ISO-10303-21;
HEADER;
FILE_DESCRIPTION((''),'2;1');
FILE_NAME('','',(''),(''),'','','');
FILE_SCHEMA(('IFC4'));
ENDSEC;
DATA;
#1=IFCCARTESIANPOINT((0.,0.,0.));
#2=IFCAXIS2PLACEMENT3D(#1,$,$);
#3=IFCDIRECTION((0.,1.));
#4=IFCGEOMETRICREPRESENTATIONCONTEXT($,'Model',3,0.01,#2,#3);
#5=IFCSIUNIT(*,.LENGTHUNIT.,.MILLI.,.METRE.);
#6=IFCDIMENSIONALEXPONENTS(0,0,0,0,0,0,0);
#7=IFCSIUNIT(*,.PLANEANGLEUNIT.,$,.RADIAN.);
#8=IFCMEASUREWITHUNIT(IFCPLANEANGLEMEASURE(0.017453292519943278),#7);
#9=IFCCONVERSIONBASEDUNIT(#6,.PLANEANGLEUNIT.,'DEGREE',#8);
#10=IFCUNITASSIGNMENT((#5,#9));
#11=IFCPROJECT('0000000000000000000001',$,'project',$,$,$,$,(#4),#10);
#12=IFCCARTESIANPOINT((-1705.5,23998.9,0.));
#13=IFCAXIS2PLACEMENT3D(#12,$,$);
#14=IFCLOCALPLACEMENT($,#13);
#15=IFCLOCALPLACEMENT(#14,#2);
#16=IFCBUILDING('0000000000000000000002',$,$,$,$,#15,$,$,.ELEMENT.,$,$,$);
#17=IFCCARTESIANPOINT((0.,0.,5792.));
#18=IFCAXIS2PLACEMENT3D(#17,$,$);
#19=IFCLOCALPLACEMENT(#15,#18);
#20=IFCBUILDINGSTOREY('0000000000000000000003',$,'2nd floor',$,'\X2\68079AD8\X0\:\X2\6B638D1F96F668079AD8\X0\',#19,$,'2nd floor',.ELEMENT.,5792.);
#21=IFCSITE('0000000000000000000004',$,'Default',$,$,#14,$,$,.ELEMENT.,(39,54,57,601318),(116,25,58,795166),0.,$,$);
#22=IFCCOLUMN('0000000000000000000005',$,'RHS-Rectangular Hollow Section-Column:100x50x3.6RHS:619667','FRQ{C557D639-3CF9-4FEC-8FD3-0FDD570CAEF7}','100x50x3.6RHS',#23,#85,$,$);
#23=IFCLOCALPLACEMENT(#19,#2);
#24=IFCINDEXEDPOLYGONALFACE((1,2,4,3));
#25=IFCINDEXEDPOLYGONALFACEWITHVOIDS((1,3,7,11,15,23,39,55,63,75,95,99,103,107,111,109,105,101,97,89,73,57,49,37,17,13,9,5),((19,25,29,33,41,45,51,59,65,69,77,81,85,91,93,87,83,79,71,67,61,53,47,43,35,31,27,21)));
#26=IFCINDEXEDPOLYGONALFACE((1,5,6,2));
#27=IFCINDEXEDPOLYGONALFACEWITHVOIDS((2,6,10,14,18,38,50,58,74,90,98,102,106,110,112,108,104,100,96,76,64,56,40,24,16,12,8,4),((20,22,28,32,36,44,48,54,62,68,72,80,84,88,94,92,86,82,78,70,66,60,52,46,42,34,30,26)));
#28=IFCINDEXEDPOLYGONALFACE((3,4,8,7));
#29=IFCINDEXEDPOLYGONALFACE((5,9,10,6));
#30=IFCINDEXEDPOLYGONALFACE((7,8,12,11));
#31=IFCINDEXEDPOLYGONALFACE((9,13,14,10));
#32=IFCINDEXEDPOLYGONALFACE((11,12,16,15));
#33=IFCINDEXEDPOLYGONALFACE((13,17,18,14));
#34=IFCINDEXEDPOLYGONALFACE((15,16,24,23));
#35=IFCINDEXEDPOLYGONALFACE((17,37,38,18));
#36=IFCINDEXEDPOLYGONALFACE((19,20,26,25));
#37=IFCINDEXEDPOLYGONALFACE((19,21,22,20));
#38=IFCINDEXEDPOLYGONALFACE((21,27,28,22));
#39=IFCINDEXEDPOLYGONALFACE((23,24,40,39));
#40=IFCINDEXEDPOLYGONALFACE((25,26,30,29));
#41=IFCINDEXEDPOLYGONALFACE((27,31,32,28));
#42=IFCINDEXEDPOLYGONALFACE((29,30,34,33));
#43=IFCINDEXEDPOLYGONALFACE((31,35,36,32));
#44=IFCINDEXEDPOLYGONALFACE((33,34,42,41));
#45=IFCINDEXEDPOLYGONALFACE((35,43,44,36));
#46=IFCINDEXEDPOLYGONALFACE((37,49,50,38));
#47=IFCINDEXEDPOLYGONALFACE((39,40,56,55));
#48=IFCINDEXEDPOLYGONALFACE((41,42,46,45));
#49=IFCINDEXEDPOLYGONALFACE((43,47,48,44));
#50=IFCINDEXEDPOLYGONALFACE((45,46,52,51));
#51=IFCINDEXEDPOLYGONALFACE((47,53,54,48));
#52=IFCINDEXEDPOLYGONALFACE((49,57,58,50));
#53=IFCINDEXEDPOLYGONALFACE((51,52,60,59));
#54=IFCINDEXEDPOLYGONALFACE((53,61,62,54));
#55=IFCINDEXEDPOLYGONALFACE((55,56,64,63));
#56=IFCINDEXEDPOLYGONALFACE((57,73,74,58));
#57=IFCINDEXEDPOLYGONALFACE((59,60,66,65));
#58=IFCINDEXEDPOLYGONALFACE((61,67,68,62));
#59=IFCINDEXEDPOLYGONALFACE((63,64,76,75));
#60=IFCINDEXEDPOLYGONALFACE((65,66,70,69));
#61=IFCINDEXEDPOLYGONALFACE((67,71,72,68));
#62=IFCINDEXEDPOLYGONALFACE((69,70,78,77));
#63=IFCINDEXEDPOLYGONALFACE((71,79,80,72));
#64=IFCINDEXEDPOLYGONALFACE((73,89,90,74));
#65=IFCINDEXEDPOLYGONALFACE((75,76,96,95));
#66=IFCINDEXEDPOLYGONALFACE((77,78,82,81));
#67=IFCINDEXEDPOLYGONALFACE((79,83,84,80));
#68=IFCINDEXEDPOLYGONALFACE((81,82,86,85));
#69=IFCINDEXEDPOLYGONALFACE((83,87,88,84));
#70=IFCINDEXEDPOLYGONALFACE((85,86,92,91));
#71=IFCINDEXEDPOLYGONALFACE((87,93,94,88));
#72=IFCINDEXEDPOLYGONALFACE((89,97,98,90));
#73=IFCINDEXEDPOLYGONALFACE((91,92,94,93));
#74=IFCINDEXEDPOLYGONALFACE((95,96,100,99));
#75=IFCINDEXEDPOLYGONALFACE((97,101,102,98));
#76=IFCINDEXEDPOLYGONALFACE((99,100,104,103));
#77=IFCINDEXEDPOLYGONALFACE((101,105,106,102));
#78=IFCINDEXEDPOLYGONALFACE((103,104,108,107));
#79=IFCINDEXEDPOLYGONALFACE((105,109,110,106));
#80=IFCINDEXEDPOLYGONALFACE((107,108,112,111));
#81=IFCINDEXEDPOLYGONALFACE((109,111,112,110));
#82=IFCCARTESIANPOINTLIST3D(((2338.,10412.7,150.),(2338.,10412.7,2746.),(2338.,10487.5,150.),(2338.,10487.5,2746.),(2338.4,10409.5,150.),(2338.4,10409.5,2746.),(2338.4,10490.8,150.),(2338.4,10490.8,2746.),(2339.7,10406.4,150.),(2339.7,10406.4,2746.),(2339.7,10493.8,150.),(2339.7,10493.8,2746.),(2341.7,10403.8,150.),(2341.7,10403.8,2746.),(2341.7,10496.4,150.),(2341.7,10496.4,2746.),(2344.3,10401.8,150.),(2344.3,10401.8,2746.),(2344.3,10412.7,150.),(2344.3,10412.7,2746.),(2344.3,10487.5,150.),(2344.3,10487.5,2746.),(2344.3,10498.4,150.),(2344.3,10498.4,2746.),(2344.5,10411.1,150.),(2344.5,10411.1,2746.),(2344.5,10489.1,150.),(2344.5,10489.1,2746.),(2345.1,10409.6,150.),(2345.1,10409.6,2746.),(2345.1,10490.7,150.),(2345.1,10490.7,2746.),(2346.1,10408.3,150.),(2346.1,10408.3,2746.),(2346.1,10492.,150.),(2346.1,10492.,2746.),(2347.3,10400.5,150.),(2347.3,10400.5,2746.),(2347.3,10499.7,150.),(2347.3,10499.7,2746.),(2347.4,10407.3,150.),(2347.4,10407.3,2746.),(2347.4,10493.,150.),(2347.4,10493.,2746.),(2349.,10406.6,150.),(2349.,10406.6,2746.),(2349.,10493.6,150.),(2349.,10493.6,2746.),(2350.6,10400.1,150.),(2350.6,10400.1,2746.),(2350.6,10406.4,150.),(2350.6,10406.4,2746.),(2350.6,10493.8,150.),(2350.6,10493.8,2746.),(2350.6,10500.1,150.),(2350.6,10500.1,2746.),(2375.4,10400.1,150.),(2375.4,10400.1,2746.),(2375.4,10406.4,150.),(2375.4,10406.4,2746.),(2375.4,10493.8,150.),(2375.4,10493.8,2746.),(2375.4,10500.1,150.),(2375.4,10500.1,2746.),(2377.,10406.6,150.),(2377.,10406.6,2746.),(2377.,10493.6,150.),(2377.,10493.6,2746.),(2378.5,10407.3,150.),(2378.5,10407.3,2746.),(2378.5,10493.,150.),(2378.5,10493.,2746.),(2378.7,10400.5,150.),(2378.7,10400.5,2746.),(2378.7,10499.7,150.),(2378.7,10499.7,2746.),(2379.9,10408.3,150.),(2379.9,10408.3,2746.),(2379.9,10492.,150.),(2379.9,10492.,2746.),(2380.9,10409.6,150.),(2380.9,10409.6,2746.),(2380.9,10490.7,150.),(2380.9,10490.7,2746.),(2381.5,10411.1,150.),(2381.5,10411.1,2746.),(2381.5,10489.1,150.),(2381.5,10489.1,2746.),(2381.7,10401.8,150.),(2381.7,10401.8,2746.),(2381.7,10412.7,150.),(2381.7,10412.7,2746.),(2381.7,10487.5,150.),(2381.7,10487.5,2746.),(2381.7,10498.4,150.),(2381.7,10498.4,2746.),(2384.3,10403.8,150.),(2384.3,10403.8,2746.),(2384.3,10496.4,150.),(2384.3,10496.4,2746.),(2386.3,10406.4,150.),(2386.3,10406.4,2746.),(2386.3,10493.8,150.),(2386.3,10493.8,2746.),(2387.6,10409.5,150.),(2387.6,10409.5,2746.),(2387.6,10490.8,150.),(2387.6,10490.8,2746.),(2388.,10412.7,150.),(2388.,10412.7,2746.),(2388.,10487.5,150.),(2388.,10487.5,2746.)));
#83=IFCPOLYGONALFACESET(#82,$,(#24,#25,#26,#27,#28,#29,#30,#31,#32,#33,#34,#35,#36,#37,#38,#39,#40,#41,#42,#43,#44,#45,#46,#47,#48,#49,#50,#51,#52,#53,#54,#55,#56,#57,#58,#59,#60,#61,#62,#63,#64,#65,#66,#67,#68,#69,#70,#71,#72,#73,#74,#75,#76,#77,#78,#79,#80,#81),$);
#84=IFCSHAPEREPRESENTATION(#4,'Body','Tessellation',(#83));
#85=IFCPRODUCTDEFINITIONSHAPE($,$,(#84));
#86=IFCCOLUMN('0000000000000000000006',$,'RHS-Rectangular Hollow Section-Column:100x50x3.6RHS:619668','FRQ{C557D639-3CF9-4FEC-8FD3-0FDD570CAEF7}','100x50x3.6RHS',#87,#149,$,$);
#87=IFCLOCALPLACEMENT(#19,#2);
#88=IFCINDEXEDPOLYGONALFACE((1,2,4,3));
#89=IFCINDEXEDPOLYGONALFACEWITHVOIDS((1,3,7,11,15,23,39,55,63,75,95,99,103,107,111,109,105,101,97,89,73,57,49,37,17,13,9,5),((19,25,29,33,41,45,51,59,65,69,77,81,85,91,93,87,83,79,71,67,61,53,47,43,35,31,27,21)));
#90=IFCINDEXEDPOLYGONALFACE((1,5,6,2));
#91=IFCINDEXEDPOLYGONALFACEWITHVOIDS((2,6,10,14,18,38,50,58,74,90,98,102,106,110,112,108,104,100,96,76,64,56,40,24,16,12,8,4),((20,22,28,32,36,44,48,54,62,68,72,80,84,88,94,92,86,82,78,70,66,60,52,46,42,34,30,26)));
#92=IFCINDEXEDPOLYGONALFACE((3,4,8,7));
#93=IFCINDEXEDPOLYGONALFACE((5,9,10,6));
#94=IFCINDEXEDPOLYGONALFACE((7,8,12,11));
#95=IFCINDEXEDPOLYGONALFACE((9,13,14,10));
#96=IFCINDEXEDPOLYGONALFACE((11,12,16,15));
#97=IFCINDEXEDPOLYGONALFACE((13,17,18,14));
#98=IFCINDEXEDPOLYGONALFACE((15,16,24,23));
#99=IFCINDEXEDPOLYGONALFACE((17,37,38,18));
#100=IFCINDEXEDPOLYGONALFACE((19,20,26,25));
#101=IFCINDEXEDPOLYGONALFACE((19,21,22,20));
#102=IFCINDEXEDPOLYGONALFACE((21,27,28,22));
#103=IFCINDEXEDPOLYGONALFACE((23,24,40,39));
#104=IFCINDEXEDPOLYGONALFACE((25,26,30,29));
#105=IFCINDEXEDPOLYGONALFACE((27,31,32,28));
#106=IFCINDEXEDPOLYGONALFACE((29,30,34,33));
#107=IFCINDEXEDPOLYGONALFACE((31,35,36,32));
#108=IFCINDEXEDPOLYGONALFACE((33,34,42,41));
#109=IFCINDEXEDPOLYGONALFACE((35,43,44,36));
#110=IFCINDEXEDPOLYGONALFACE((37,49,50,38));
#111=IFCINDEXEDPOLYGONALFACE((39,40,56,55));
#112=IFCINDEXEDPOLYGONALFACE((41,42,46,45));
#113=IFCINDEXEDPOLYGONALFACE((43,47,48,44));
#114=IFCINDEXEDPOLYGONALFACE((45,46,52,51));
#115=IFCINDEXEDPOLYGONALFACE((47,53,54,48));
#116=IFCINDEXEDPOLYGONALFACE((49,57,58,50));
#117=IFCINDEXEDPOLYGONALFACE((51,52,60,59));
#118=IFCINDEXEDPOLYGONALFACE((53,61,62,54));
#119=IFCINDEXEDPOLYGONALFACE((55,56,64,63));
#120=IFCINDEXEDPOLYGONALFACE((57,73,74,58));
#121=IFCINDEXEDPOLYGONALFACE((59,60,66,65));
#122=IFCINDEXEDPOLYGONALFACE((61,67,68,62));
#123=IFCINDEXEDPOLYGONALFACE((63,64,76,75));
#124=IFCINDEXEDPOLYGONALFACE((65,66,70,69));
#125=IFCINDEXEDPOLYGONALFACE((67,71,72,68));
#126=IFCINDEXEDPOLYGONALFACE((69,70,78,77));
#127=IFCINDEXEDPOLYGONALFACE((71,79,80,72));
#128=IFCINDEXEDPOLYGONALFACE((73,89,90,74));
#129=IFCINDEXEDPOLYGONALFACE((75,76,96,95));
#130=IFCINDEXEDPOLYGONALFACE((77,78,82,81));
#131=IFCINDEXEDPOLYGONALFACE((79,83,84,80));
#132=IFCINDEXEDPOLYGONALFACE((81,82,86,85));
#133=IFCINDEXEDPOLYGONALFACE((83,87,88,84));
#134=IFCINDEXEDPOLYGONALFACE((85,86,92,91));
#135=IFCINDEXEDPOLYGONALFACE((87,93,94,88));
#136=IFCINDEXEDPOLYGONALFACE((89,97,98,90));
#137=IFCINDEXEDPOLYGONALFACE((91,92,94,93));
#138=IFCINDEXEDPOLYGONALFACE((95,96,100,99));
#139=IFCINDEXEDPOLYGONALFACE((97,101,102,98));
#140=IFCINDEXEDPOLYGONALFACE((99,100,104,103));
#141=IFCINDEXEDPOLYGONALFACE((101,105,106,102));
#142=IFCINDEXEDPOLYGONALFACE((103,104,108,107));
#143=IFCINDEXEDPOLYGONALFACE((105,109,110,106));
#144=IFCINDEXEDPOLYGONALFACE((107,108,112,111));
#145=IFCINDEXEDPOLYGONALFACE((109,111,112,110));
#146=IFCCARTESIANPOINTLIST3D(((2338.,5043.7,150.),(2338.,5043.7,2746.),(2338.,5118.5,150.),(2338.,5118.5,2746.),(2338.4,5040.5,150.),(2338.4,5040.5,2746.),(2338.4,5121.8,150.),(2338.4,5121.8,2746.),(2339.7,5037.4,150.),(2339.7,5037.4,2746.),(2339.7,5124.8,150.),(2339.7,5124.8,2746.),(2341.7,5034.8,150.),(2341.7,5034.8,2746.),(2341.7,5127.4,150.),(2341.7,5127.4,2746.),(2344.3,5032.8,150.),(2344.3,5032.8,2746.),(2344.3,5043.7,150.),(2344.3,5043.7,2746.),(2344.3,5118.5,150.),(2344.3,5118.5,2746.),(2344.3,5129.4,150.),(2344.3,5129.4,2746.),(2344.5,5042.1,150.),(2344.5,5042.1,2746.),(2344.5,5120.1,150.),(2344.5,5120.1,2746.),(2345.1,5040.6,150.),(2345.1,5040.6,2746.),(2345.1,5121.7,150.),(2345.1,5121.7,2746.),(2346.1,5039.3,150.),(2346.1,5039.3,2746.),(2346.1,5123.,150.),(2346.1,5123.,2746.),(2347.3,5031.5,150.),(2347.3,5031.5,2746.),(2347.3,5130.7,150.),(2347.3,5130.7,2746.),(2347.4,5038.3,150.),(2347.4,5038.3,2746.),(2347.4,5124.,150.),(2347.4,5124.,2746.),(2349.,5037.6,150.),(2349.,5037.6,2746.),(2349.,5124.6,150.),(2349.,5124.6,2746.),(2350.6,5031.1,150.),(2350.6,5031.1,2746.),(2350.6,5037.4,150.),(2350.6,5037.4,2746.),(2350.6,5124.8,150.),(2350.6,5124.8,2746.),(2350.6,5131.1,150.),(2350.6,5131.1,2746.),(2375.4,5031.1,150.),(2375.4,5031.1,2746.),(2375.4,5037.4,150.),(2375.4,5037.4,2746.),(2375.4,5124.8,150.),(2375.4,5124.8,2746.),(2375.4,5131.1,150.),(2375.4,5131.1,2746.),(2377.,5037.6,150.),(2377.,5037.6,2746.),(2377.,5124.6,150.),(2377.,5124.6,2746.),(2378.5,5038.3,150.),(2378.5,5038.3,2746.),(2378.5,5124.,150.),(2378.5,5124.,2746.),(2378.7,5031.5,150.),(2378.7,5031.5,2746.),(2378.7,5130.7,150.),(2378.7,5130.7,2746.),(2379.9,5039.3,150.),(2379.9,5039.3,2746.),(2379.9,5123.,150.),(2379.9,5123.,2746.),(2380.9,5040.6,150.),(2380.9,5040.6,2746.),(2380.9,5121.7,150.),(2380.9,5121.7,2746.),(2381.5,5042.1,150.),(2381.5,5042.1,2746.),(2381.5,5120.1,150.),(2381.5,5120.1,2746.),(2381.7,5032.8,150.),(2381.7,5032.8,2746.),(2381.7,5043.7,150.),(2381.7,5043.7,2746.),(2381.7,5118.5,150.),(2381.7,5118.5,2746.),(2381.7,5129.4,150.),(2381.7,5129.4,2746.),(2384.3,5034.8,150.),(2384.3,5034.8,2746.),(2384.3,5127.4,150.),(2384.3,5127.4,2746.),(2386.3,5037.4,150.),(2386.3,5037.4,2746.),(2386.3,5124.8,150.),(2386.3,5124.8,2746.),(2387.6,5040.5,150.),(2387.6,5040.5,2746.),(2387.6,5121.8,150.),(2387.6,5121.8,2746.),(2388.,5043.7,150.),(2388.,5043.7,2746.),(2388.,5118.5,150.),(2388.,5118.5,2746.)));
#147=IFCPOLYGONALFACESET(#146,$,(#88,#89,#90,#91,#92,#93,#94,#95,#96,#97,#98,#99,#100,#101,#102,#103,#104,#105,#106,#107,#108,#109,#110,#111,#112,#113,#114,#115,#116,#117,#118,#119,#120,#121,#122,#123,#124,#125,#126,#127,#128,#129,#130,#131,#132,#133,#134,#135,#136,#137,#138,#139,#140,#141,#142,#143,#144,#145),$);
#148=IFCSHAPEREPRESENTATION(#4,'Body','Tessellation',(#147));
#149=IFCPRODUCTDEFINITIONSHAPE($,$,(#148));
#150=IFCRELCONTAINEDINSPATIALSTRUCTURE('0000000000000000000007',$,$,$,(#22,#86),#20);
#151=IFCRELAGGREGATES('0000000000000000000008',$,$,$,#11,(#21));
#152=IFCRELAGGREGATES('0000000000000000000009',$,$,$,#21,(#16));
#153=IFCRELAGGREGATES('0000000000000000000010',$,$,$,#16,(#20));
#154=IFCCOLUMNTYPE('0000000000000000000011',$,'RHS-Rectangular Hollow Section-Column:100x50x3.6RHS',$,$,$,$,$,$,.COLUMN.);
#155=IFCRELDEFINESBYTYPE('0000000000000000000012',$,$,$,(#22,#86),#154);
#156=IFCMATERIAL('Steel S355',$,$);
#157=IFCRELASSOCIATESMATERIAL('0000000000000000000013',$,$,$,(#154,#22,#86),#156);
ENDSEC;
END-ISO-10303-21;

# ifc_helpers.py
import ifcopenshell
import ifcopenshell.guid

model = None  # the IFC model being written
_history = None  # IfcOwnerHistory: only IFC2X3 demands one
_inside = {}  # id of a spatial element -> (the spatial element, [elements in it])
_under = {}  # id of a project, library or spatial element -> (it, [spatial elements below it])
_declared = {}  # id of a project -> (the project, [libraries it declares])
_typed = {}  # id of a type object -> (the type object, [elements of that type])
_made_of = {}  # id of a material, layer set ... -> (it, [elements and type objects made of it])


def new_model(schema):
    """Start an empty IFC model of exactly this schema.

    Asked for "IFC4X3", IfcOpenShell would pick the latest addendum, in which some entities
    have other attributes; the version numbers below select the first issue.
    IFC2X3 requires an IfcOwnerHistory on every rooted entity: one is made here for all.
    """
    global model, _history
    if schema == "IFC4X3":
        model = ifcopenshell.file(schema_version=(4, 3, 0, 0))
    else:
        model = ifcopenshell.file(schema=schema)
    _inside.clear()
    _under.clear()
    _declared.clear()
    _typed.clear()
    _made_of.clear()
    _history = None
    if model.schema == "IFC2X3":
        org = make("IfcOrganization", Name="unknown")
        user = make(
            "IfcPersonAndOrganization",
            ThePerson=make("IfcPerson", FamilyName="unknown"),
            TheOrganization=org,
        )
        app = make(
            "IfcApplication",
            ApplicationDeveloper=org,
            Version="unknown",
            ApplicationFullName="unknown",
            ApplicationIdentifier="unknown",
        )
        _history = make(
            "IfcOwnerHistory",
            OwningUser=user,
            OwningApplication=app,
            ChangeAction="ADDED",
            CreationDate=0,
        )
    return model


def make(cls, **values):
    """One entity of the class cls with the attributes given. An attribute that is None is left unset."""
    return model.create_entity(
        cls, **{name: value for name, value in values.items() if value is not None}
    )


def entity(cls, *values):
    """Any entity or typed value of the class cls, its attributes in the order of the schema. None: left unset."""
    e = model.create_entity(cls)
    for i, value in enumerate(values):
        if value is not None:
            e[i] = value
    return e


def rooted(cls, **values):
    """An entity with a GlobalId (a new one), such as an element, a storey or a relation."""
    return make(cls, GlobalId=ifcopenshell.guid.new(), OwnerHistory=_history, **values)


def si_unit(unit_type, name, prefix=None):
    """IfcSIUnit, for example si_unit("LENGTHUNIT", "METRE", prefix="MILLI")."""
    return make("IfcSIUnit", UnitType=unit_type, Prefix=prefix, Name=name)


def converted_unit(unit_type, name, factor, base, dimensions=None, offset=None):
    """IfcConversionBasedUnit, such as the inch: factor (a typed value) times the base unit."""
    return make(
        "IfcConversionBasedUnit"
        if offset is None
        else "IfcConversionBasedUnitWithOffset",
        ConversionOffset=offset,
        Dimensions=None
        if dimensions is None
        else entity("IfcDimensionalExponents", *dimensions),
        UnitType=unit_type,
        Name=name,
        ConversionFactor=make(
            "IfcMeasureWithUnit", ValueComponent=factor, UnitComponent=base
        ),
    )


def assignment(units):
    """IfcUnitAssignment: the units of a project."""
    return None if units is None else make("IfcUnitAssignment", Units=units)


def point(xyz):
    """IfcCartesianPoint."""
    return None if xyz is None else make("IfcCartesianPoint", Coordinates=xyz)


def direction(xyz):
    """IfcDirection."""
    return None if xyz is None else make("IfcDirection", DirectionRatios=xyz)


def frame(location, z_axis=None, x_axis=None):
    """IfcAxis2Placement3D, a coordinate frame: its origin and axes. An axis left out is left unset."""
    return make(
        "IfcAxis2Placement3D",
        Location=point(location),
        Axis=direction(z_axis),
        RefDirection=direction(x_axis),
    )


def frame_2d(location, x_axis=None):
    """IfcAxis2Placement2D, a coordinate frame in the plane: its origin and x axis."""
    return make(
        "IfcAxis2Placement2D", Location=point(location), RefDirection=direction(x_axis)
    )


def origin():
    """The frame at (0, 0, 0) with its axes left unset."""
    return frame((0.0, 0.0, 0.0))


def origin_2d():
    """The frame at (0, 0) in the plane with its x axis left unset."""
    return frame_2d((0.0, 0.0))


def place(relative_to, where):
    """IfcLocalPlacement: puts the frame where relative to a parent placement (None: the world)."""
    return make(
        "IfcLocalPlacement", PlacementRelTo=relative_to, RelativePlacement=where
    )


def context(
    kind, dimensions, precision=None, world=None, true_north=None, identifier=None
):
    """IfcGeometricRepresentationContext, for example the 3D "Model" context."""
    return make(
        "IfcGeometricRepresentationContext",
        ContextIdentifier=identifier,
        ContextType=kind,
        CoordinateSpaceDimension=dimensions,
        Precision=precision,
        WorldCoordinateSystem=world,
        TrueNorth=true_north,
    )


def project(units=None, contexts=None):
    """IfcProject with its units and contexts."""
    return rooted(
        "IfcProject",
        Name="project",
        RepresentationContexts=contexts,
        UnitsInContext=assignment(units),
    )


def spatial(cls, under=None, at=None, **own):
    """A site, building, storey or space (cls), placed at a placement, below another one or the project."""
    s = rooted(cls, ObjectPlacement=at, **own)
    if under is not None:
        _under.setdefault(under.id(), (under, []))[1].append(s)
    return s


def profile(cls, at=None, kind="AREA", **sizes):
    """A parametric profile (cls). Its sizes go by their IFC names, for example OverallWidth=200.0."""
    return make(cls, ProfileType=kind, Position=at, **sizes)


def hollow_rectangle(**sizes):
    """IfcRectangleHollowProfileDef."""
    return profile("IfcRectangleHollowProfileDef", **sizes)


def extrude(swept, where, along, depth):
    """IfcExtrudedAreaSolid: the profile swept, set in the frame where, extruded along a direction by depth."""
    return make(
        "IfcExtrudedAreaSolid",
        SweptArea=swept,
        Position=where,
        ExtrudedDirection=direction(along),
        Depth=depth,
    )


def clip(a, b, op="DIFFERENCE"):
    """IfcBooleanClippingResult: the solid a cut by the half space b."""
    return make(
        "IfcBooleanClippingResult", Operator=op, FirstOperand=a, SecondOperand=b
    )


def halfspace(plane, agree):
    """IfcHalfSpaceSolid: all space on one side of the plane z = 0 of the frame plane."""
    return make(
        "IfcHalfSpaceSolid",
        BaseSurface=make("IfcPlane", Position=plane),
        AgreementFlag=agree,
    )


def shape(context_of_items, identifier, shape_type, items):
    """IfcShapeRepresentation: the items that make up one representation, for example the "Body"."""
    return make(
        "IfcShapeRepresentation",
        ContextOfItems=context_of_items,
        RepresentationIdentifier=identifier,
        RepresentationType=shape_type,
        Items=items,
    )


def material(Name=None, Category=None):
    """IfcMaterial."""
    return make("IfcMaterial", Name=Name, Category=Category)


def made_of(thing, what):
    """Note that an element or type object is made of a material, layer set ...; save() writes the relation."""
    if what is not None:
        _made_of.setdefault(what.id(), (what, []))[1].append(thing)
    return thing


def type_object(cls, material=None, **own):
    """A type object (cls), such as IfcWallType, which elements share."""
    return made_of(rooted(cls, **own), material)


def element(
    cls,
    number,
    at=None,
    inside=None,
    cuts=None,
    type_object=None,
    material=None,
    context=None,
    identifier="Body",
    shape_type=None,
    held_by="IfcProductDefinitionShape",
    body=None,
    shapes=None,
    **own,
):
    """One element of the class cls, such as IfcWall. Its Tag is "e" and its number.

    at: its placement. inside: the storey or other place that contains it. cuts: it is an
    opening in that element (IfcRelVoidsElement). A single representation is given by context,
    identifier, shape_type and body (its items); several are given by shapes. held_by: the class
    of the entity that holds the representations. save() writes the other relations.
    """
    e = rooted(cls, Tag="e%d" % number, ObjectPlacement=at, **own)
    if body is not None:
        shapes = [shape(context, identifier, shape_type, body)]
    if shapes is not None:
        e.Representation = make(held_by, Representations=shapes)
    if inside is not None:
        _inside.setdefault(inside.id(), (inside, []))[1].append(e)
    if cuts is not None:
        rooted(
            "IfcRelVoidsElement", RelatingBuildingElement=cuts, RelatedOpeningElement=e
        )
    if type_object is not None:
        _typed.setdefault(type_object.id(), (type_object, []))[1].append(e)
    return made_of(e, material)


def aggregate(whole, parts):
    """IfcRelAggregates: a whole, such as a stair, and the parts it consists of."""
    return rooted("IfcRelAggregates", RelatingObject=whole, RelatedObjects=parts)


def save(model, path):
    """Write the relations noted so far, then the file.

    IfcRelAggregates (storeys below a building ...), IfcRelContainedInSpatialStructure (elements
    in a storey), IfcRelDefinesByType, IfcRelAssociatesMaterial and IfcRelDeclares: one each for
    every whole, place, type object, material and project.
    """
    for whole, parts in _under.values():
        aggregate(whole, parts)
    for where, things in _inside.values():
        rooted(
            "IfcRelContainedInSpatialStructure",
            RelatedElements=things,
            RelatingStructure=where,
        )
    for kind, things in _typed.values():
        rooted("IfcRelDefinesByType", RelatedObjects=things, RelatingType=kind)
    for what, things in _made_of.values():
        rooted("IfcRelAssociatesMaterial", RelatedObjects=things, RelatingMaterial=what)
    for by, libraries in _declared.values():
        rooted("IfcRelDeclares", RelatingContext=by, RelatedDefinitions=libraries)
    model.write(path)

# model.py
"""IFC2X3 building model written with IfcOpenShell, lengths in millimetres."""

from ifc_helpers import new_model, entity, si_unit, converted_unit, direction, frame, origin, origin_2d, place, context, project, spatial, hollow_rectangle, extrude, clip, halfspace, material, type_object, element, save


model = new_model("IFC2X3")

# Units and contexts
model_context = context("Model", 3, precision=0.01, world=origin(), true_north=direction((0.0, 1.0)))
ifc_project = project(units=[si_unit("LENGTHUNIT", "METRE", prefix="MILLI"), converted_unit("PLANEANGLEUNIT", "DEGREE", entity("IfcPlaneAngleMeasure", 0.017453292519943278), si_unit("PLANEANGLEUNIT", "RADIAN"), dimensions=[0, 0, 0, 0, 0, 0, 0])], contexts=[model_context])

# Site, building, storey
site_placement = place(None, frame((-1705.5, 23998.9, 0.0)))
site = spatial("IfcSite", under=ifc_project, at=site_placement, Name="Default", CompositionType="ELEMENT", RefLatitude=(39, 54, 57, 601318), RefLongitude=(116, 25, 58, 795166), RefElevation=0.0)
building_placement = place(site_placement, origin())
building = spatial("IfcBuilding", under=site, at=building_placement, CompositionType="ELEMENT")
storey_placement = place(building_placement, frame((0.0, 0.0, 5792.0)))
storey = spatial("IfcBuildingStorey", under=building, at=storey_placement, Name="2nd floor", ObjectType="标高:正负零标高", LongName="2nd floor", CompositionType="ELEMENT", Elevation=5792.0)

# Columns
ifc_material_1 = material(Name="Steel S355")
column_type = type_object("IfcColumnType", Name="RHS-Rectangular Hollow Section-Column:100x50x3.6RHS", PredefinedType="COLUMN", material=ifc_material_1)
column_1_placement = place(storey_placement, frame((2363.0, 10450.1, 2746.0), z_axis=(0.0, 0.0, 1.0), x_axis=(-1.0, 0.0, 0.0)))
element("IfcColumn", 1, at=column_1_placement, inside=storey, type_object=column_type, material=ifc_material_1, Name="RHS-Rectangular Hollow Section-Column:100x50x3.6RHS:619667", Description="FRQ{C557D639-3CF9-4FEC-8FD3-0FDD570CAEF7}", ObjectType="100x50x3.6RHS", context=model_context, shape_type="Clipping", body=[
    clip(extrude(hollow_rectangle(XDim=50.0, YDim=100.0, WallThickness=6.3, InnerFilletRadius=6.3, OuterFilletRadius=12.6, at=origin_2d()), origin(), (0.0, 0.0, -1.0), 2651.9), halfspace(frame((2363.0, 10450.1, -2596.0), z_axis=(0.0, 0.0, 1.0), x_axis=(-1.0, 0.0, 0.0)), True)),
])
column_2_placement = place(storey_placement, frame((2363.0, 5081.1, 2746.0), z_axis=(0.0, 0.0, 1.0), x_axis=(-1.0, 0.0, 0.0)))
element("IfcColumn", 2, at=column_2_placement, inside=storey, type_object=column_type, material=ifc_material_1, Name="RHS-Rectangular Hollow Section-Column:100x50x3.6RHS:619668", Description="FRQ{C557D639-3CF9-4FEC-8FD3-0FDD570CAEF7}", ObjectType="100x50x3.6RHS", context=model_context, shape_type="Clipping", body=[
    clip(extrude(hollow_rectangle(XDim=50.0, YDim=100.0, WallThickness=6.3, InnerFilletRadius=6.3, OuterFilletRadius=12.6, at=origin_2d()), origin(), (0.0, 0.0, -1.0), 2651.9), halfspace(frame((2363.0, 5081.1, -2596.0), z_axis=(0.0, 0.0, 1.0), x_axis=(-1.0, 0.0, 0.0)), True)),
])

save(model, "model.ifc")
